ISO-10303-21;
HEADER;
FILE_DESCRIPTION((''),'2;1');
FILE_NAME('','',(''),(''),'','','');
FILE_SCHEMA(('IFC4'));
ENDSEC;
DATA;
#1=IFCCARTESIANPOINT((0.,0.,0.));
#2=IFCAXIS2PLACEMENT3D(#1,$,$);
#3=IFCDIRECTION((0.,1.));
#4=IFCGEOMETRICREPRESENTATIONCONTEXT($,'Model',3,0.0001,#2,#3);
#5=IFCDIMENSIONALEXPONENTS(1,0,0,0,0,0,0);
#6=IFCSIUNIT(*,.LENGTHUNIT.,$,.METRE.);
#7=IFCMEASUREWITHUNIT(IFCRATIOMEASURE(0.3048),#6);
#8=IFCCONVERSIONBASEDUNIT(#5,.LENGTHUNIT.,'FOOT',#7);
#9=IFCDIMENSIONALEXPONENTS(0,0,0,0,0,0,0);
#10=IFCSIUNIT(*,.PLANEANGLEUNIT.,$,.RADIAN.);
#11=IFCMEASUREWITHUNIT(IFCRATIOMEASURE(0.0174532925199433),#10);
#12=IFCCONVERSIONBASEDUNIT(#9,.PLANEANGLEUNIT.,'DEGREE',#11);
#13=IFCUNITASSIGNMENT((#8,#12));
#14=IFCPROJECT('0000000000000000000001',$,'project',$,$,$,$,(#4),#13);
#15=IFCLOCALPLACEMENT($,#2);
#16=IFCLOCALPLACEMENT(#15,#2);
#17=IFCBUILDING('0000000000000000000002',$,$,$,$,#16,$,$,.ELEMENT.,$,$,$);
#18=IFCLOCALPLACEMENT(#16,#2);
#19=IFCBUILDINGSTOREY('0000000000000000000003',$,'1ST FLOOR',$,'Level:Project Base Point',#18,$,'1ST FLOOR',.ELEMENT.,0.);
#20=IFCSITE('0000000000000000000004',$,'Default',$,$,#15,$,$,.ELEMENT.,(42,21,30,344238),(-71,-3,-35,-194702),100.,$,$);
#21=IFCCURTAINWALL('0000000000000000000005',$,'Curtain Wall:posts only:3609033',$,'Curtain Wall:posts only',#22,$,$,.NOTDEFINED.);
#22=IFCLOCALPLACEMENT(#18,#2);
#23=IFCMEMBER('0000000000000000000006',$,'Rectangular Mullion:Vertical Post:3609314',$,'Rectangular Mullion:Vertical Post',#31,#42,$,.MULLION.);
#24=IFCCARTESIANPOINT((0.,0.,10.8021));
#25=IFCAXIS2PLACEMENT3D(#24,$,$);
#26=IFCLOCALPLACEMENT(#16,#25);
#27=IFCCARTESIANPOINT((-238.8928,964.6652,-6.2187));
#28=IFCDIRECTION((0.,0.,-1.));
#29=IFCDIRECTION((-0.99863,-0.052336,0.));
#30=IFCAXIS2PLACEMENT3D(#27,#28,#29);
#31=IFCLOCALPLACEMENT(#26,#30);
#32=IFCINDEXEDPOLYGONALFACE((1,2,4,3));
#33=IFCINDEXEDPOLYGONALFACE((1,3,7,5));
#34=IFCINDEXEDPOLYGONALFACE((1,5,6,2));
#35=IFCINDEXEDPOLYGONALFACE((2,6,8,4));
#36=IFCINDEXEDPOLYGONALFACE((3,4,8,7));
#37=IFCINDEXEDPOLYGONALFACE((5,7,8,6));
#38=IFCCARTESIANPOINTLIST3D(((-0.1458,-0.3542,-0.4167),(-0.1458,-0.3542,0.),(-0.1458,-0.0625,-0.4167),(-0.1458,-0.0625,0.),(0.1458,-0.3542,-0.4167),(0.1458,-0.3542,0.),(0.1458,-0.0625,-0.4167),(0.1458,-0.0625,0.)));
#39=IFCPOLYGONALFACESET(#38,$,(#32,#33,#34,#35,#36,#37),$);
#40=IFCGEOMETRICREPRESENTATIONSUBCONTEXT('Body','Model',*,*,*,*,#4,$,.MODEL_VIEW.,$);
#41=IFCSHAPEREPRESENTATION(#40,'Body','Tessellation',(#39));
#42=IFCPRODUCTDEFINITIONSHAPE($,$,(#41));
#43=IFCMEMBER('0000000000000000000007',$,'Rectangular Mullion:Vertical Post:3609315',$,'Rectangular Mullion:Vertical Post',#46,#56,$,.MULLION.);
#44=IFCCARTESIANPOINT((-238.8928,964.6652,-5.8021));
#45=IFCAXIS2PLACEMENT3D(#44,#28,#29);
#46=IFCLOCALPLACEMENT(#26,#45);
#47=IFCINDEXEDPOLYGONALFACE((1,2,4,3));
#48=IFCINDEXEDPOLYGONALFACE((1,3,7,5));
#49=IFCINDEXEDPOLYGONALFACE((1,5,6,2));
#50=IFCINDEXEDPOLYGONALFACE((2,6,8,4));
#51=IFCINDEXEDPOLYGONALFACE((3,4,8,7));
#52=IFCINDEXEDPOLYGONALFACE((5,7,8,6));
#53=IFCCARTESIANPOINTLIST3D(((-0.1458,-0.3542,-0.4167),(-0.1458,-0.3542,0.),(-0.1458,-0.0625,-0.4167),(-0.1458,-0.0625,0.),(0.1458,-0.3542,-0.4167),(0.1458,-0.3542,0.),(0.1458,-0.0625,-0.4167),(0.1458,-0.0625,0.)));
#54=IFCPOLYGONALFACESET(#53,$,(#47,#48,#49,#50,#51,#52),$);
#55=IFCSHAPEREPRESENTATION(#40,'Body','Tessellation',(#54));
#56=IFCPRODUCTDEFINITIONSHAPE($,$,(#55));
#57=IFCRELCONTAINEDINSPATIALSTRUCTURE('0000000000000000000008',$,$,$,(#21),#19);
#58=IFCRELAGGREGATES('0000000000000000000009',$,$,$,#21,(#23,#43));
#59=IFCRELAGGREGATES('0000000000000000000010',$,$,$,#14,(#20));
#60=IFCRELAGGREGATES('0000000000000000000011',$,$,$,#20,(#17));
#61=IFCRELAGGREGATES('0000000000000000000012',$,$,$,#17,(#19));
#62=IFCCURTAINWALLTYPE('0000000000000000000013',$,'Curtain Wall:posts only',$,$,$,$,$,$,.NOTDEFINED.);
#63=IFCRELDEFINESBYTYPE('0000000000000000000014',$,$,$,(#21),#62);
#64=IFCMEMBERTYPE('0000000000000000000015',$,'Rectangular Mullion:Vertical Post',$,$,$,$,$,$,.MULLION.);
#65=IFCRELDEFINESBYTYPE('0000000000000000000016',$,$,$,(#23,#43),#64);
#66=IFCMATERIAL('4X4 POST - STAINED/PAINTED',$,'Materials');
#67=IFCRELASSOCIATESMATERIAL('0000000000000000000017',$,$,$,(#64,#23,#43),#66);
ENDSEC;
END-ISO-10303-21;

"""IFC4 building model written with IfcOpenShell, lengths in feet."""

from ifc_helpers import new_model, entity, si_unit, converted_unit, direction, frame, origin, origin_2d_with_axis, place, context, subcontext, project, spatial, rectangle, extrude, source, transform, mapped, material, material_profile, profile_set, profile_usage, type_object, type_shapes, element, aggregate, save


model = new_model("IFC4")

# Units and contexts
model_context = context("Model", 3, precision=0.0001, world=origin(), true_north=direction((0.0, 1.0)))
body_context = subcontext(model_context, "Body", "Model", "MODEL_VIEW")
ifc_project = project(units=[converted_unit("LENGTHUNIT", "FOOT", entity("IfcRatioMeasure", 0.3048), si_unit("LENGTHUNIT", "METRE"), dimensions=[1, 0, 0, 0, 0, 0, 0]), converted_unit("PLANEANGLEUNIT", "DEGREE", entity("IfcRatioMeasure", 0.0174532925199433), si_unit("PLANEANGLEUNIT", "RADIAN"), dimensions=[0, 0, 0, 0, 0, 0, 0])], contexts=[model_context])

# Site, building, storey
site_placement = place(None, origin())
site = spatial("IfcSite", under=ifc_project, at=site_placement, Name="Default", CompositionType="ELEMENT", RefLatitude=(42, 21, 30, 344238), RefLongitude=(-71, -3, -35, -194702), RefElevation=100.0)
building_placement = place(site_placement, origin())
building = spatial("IfcBuilding", under=site, at=building_placement, CompositionType="ELEMENT")
storey_placement = place(building_placement, origin())
storey = spatial("IfcBuildingStorey", under=building, at=storey_placement, Name="1ST FLOOR", ObjectType="Level:Project Base Point", LongName="1ST FLOOR", CompositionType="ELEMENT", Elevation=0.0)

# Curtain wall, members
curtain_wall_type_1 = type_object("IfcCurtainWallType", Name="Curtain Wall:posts only", PredefinedType="NOTDEFINED")
curtain_wall_1_placement = place(storey_placement, origin())
curtain_wall_1 = element("IfcCurtainWall", 1, at=curtain_wall_1_placement, inside=storey, type_object=curtain_wall_type_1, Name="Curtain Wall:posts only:3609033", ObjectType="Curtain Wall:posts only", PredefinedType="NOTDEFINED")
ifc_material_1 = material(Name="4X4 POST - STAINED/PAINTED", Category="Materials")
ifc_material_profile_1 = material_profile(ifc_material_1, rectangle(XDim=0.2917, YDim=0.2917, at=origin_2d_with_axis()), Name="Vertical Post")
ifc_profile_set_1 = profile_set([ifc_material_profile_1], Name="Vertical Post")
placement = place(building_placement, frame((0.0, 0.0, 10.8021)))
member_type_1 = type_object("IfcMemberType", Name="Rectangular Mullion:Vertical Post", PredefinedType="MULLION", material=ifc_profile_set_1)
shared_shape_1 = source(origin(), body_context, "Body", "SweptSolid", [
    extrude(rectangle(XDim=0.2917, YDim=0.2917, at=origin_2d_with_axis()), frame((0.0, -0.2083, -0.4167), z_axis=(0.0, 0.0, 1.0), x_axis=(0.0, -1.0, 0.0)), (0.0, 0.0, 1.0), 0.4167),
])
type_shapes(member_type_1, [shared_shape_1])
ifc_profile_usage_1 = profile_usage(ifc_profile_set_1)
member_1_placement = place(placement, frame((-238.8928, 964.6652, -6.2187), z_axis=(0.0, 0.0, -1.0), x_axis=(-0.99863, -0.052336, 0.0)))
member_1 = element("IfcMember", 2, at=member_1_placement, type_object=member_type_1, material=ifc_profile_usage_1, Name="Rectangular Mullion:Vertical Post:3609314", ObjectType="Rectangular Mullion:Vertical Post", PredefinedType="MULLION", context=body_context, shape_type="MappedRepresentation", body=[
    mapped(shared_shape_1, transform((0.0, 0.0, 0.0), scale=1.0)),
])
ifc_profile_usage_2 = profile_usage(ifc_profile_set_1)
member_2_placement = place(placement, frame((-238.8928, 964.6652, -5.8021), z_axis=(0.0, 0.0, -1.0), x_axis=(-0.99863, -0.052336, 0.0)))
member_2 = element("IfcMember", 3, at=member_2_placement, type_object=member_type_1, material=ifc_profile_usage_2, Name="Rectangular Mullion:Vertical Post:3609315", ObjectType="Rectangular Mullion:Vertical Post", PredefinedType="MULLION", context=body_context, shape_type="MappedRepresentation", body=[
    mapped(shared_shape_1, transform((0.0, 0.0, 0.0), scale=1.0)),
])
aggregate(curtain_wall_1, [member_1, member_2])

save(model, "model.ifc")
